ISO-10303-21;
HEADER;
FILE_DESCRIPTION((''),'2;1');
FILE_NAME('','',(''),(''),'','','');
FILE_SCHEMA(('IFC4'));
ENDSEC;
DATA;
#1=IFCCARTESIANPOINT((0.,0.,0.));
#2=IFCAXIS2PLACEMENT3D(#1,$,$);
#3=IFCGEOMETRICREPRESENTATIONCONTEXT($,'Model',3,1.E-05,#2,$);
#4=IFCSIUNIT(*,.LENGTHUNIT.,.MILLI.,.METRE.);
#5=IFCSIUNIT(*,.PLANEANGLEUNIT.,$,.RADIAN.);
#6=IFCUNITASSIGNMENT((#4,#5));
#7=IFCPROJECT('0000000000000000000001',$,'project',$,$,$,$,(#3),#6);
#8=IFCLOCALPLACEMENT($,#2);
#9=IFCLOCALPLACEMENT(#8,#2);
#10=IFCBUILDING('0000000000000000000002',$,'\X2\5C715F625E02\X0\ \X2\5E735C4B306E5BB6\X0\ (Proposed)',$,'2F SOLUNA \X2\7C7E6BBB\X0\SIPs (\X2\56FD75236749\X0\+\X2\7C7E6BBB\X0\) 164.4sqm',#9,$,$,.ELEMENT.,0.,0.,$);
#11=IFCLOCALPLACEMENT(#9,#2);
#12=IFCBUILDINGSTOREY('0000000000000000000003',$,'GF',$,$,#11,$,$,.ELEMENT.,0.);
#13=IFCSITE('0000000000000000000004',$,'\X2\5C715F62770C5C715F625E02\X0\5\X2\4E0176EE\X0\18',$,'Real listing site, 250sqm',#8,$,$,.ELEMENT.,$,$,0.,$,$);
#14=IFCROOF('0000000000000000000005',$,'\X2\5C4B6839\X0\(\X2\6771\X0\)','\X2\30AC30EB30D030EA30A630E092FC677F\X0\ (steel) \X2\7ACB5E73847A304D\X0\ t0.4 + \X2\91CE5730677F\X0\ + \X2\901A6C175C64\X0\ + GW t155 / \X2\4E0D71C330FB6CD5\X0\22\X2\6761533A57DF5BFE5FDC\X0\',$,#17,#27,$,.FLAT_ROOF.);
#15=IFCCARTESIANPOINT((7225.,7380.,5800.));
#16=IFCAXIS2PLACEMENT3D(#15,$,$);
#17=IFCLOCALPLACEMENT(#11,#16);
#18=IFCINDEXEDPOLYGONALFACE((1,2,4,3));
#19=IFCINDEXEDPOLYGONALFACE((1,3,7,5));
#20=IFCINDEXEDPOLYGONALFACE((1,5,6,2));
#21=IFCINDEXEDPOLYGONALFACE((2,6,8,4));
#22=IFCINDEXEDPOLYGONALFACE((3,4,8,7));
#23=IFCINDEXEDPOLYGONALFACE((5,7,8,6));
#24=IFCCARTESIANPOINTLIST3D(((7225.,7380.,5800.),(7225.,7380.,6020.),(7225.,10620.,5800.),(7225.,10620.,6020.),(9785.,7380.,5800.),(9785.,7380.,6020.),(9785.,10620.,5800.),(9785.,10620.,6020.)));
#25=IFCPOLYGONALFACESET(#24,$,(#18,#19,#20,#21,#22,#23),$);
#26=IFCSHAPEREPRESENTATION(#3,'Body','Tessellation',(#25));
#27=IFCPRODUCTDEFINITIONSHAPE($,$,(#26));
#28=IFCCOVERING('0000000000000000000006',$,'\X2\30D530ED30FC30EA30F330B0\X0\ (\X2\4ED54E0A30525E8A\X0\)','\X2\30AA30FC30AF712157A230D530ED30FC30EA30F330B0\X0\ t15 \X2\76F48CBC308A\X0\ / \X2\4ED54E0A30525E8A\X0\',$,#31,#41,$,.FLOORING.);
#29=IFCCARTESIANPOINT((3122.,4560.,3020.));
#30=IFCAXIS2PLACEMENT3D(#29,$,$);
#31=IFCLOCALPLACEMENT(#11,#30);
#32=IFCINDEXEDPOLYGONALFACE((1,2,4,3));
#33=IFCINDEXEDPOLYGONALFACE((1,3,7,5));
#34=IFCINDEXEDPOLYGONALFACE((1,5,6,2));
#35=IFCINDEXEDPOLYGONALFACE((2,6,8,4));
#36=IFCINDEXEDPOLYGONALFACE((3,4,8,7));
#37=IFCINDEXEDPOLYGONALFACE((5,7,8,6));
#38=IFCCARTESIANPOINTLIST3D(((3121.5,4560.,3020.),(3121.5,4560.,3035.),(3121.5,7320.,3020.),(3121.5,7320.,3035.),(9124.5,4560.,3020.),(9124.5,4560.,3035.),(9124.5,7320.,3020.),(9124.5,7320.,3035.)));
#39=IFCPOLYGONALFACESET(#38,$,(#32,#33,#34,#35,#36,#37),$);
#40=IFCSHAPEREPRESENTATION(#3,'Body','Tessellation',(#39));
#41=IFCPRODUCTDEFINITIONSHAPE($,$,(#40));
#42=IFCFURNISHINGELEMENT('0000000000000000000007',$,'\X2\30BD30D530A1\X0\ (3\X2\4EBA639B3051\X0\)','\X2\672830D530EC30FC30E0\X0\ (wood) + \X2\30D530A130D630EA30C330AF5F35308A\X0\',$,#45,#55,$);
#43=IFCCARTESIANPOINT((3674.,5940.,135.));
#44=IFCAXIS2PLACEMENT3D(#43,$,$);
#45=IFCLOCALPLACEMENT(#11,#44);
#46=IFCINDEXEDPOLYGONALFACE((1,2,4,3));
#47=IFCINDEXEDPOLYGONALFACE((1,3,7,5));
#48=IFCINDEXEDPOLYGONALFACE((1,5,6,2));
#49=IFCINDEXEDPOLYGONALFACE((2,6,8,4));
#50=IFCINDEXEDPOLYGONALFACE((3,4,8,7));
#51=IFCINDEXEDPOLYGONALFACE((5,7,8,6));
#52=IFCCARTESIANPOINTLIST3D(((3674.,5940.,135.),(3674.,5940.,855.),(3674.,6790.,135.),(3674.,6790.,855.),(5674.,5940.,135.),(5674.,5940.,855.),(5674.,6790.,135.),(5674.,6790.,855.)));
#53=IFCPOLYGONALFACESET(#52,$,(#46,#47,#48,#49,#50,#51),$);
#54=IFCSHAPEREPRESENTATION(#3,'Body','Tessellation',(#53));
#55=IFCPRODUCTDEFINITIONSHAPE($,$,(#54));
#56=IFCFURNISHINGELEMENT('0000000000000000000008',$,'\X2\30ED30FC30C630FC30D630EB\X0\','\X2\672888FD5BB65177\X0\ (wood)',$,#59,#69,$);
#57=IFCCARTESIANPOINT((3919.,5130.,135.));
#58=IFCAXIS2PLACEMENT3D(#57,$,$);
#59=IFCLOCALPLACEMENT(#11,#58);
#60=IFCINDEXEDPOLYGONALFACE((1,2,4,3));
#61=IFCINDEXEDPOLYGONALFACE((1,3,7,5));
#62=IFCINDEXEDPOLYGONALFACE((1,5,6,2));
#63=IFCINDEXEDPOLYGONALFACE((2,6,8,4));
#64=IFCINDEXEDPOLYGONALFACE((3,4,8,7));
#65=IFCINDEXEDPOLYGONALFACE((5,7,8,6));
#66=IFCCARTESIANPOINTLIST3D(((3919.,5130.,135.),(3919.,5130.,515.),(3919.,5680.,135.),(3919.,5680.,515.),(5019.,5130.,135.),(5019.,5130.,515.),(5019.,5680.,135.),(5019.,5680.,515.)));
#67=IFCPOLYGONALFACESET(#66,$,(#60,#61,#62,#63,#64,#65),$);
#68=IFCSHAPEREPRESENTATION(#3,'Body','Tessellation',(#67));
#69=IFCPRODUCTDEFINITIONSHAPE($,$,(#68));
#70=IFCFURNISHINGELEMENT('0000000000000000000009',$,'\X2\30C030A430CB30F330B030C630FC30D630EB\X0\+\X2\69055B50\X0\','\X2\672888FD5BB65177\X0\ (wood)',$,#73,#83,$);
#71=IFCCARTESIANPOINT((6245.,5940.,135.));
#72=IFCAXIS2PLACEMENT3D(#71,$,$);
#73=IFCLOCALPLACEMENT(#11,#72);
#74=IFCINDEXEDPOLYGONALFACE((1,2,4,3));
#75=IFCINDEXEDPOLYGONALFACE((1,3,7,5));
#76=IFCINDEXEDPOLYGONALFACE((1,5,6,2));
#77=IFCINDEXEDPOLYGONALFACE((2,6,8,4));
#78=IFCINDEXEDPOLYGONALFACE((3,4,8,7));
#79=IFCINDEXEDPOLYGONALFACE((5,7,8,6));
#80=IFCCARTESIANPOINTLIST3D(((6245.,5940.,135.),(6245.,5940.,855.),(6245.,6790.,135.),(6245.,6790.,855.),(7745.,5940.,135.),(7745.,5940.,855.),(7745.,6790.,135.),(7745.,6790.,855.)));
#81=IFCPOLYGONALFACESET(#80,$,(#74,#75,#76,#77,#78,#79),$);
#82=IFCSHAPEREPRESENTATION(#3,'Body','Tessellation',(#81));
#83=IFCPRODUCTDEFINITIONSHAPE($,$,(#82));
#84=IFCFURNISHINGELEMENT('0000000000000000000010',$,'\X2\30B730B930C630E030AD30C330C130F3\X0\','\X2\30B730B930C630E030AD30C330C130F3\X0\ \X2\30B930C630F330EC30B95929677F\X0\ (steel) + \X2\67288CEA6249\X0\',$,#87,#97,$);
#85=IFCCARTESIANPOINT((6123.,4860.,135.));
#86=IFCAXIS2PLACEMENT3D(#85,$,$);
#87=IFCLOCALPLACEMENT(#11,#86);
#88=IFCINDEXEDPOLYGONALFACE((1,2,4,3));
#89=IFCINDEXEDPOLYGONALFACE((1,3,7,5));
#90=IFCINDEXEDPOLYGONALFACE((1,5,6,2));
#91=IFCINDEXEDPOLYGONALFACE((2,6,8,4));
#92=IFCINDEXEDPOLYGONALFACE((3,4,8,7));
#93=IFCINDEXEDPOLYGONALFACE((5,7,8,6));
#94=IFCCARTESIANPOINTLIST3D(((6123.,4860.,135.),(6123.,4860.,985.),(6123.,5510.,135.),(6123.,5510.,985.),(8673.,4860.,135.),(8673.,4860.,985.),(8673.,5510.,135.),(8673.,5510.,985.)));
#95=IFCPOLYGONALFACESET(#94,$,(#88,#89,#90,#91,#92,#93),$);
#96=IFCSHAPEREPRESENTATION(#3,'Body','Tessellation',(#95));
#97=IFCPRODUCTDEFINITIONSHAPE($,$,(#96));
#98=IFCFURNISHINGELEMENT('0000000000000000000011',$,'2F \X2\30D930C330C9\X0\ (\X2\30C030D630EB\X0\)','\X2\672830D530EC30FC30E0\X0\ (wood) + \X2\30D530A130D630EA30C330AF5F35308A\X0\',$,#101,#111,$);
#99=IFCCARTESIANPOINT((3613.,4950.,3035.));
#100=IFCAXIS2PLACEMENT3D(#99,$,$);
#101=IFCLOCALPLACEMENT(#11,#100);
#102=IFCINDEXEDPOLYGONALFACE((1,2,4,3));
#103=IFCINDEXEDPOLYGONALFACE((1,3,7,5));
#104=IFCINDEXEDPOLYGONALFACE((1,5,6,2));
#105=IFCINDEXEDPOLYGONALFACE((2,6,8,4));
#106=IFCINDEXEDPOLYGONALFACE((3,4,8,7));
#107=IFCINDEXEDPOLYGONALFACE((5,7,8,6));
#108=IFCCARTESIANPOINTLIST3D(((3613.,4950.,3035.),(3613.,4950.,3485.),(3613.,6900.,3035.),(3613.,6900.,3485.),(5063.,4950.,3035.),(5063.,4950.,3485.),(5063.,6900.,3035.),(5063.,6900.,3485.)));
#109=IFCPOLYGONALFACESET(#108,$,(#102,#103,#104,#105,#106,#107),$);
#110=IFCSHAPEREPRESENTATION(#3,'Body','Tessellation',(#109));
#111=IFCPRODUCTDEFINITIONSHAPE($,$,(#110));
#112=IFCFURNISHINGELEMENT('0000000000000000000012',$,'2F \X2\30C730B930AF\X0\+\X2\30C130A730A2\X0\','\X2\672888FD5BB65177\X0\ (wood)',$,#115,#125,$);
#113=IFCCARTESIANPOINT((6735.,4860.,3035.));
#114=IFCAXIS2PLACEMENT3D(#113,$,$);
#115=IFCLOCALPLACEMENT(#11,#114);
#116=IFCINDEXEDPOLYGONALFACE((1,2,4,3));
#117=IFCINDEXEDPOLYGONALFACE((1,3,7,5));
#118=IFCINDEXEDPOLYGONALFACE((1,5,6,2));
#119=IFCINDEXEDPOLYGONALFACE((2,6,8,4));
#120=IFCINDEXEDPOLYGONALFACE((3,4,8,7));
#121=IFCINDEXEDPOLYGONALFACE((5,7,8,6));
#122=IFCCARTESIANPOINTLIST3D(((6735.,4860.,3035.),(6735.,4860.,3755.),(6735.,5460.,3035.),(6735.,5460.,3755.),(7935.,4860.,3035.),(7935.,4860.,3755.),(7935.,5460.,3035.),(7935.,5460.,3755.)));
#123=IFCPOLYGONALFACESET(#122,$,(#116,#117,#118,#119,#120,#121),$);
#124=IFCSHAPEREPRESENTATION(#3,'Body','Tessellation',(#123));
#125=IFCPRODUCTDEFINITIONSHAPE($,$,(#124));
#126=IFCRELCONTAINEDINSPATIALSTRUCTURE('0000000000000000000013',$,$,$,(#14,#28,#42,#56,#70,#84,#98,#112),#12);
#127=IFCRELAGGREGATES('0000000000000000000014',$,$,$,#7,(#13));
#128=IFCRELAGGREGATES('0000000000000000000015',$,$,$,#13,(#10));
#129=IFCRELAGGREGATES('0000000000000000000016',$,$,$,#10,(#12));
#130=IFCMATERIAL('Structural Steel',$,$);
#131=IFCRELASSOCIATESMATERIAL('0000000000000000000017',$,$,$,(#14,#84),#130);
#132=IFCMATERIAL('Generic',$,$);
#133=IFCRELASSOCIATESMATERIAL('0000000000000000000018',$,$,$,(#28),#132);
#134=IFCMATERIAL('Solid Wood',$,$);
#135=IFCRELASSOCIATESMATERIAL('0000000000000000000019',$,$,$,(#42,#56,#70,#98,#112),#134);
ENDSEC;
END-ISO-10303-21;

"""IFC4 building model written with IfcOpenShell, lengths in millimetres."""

from ifc_helpers import new_model, si_unit, frame, frame_2d, origin, place, context, project, spatial, rectangle, extrude, material, element, save


model = new_model("IFC4")

# Units and contexts
model_context = context("Model", 3, precision=1e-05, world=origin())
ifc_project = project(units=[si_unit("LENGTHUNIT", "METRE", prefix="MILLI"), si_unit("PLANEANGLEUNIT", "RADIAN")], contexts=[model_context])

# Site, building, storey
site_placement = place(None, origin())
site = spatial("IfcSite", under=ifc_project, at=site_placement, Name="山形県山形市5丁目18", ObjectType="Real listing site, 250sqm", CompositionType="ELEMENT", RefElevation=0.0)
building_placement = place(site_placement, origin())
building = spatial("IfcBuilding", under=site, at=building_placement, Name="山形市 平屋の家 (Proposed)", ObjectType="2F SOLUNA 籾殻SIPs (国産杉+籾殻) 164.4sqm", CompositionType="ELEMENT", ElevationOfRefHeight=0.0, ElevationOfTerrain=0.0)
storey_placement = place(building_placement, origin())
storey = spatial("IfcBuildingStorey", under=building, at=storey_placement, Name="GF", CompositionType="ELEMENT", Elevation=0.0)

# Shared definitions
ifc_material_1 = material(Name="Solid Wood")

# Shared definitions
ifc_material_2 = material(Name="Generic")

# Roof
ifc_material_3 = material(Name="Structural Steel")
roof_placement = place(storey_placement, frame((7225.0, 7380.0, 5800.0)))
element("IfcRoof", 1, at=roof_placement, inside=storey, material=ifc_material_3, Name="屋根(東)", Description="ガルバリウム鋼板 (steel) 立平葺き t0.4 + 野地板 + 通気層 + GW t155 / 不燃・法22条区域対応", PredefinedType="FLAT_ROOF", context=model_context, shape_type="SweptSolid", body=[
    extrude(rectangle(XDim=2560.0, YDim=3240.0, at=frame_2d((1280.0, 1620.0))), frame((7225.0, 7380.0, 5800.0)), (0.0, 0.0, 1.0), 220.0),
])

# Covering
covering_placement = place(storey_placement, frame((3122.0, 4560.0, 3020.0)))
element("IfcCovering", 2, at=covering_placement, inside=storey, material=ifc_material_2, Name="フローリング (仕上げ床)", Description="オーク無垢フローリング t15 直貼り / 仕上げ床", PredefinedType="FLOORING", context=model_context, shape_type="SweptSolid", body=[
    extrude(rectangle(XDim=6003.0, YDim=2760.0, at=frame_2d((3001.0, 1380.0))), frame((3122.0, 4560.0, 3020.0)), (0.0, 0.0, 1.0), 15.0),
])

# Furnishing elements
furnishing_1_placement = place(storey_placement, frame((3674.0, 5940.0, 135.0)))
element("IfcFurnishingElement", 3, at=furnishing_1_placement, inside=storey, material=ifc_material_1, Name="ソファ (3人掛け)", Description="木フレーム (wood) + ファブリック張り", context=model_context, shape_type="SweptSolid", body=[
    extrude(rectangle(XDim=2000.0, YDim=850.0, at=frame_2d((1000.0, 425.0))), frame((3674.0, 5940.0, 135.0)), (0.0, 0.0, 1.0), 720.0),
])
furnishing_2_placement = place(storey_placement, frame((3919.0, 5130.0, 135.0)))
element("IfcFurnishingElement", 4, at=furnishing_2_placement, inside=storey, material=ifc_material_1, Name="ローテーブル", Description="木製家具 (wood)", context=model_context, shape_type="SweptSolid", body=[
    extrude(rectangle(XDim=1100.0, YDim=550.0, at=frame_2d((550.0, 275.0))), frame((3919.0, 5130.0, 135.0)), (0.0, 0.0, 1.0), 380.0),
])
furnishing_3_placement = place(storey_placement, frame((6245.0, 5940.0, 135.0)))
element("IfcFurnishingElement", 5, at=furnishing_3_placement, inside=storey, material=ifc_material_1, Name="ダイニングテーブル+椅子", Description="木製家具 (wood)", context=model_context, shape_type="SweptSolid", body=[
    extrude(rectangle(XDim=1500.0, YDim=850.0, at=frame_2d((750.0, 425.0))), frame((6245.0, 5940.0, 135.0)), (0.0, 0.0, 1.0), 720.0),
])
furnishing_4_placement = place(storey_placement, frame((6123.0, 4860.0, 135.0)))
element("IfcFurnishingElement", 6, at=furnishing_4_placement, inside=storey, material=ifc_material_3, Name="システムキッチン", Description="システムキッチン ステンレス天板 (steel) + 木質扉", context=model_context, shape_type="SweptSolid", body=[
    extrude(rectangle(XDim=2550.0, YDim=650.0, at=frame_2d((1275.0, 325.0))), frame((6123.0, 4860.0, 135.0)), (0.0, 0.0, 1.0), 850.0),
])
furnishing_5_placement = place(storey_placement, frame((3613.0, 4950.0, 3035.0)))
element("IfcFurnishingElement", 7, at=furnishing_5_placement, inside=storey, material=ifc_material_1, Name="2F ベッド (ダブル)", Description="木フレーム (wood) + ファブリック張り", context=model_context, shape_type="SweptSolid", body=[
    extrude(rectangle(XDim=1450.0, YDim=1950.0, at=frame_2d((725.0, 975.0))), frame((3613.0, 4950.0, 3035.0)), (0.0, 0.0, 1.0), 450.0),
])
furnishing_6_placement = place(storey_placement, frame((6735.0, 4860.0, 3035.0)))
element("IfcFurnishingElement", 8, at=furnishing_6_placement, inside=storey, material=ifc_material_1, Name="2F デスク+チェア", Description="木製家具 (wood)", context=model_context, shape_type="SweptSolid", body=[
    extrude(rectangle(XDim=1200.0, YDim=600.0, at=frame_2d((600.0, 300.0))), frame((6735.0, 4860.0, 3035.0)), (0.0, 0.0, 1.0), 720.0),
])

save(model, "model.ifc")
